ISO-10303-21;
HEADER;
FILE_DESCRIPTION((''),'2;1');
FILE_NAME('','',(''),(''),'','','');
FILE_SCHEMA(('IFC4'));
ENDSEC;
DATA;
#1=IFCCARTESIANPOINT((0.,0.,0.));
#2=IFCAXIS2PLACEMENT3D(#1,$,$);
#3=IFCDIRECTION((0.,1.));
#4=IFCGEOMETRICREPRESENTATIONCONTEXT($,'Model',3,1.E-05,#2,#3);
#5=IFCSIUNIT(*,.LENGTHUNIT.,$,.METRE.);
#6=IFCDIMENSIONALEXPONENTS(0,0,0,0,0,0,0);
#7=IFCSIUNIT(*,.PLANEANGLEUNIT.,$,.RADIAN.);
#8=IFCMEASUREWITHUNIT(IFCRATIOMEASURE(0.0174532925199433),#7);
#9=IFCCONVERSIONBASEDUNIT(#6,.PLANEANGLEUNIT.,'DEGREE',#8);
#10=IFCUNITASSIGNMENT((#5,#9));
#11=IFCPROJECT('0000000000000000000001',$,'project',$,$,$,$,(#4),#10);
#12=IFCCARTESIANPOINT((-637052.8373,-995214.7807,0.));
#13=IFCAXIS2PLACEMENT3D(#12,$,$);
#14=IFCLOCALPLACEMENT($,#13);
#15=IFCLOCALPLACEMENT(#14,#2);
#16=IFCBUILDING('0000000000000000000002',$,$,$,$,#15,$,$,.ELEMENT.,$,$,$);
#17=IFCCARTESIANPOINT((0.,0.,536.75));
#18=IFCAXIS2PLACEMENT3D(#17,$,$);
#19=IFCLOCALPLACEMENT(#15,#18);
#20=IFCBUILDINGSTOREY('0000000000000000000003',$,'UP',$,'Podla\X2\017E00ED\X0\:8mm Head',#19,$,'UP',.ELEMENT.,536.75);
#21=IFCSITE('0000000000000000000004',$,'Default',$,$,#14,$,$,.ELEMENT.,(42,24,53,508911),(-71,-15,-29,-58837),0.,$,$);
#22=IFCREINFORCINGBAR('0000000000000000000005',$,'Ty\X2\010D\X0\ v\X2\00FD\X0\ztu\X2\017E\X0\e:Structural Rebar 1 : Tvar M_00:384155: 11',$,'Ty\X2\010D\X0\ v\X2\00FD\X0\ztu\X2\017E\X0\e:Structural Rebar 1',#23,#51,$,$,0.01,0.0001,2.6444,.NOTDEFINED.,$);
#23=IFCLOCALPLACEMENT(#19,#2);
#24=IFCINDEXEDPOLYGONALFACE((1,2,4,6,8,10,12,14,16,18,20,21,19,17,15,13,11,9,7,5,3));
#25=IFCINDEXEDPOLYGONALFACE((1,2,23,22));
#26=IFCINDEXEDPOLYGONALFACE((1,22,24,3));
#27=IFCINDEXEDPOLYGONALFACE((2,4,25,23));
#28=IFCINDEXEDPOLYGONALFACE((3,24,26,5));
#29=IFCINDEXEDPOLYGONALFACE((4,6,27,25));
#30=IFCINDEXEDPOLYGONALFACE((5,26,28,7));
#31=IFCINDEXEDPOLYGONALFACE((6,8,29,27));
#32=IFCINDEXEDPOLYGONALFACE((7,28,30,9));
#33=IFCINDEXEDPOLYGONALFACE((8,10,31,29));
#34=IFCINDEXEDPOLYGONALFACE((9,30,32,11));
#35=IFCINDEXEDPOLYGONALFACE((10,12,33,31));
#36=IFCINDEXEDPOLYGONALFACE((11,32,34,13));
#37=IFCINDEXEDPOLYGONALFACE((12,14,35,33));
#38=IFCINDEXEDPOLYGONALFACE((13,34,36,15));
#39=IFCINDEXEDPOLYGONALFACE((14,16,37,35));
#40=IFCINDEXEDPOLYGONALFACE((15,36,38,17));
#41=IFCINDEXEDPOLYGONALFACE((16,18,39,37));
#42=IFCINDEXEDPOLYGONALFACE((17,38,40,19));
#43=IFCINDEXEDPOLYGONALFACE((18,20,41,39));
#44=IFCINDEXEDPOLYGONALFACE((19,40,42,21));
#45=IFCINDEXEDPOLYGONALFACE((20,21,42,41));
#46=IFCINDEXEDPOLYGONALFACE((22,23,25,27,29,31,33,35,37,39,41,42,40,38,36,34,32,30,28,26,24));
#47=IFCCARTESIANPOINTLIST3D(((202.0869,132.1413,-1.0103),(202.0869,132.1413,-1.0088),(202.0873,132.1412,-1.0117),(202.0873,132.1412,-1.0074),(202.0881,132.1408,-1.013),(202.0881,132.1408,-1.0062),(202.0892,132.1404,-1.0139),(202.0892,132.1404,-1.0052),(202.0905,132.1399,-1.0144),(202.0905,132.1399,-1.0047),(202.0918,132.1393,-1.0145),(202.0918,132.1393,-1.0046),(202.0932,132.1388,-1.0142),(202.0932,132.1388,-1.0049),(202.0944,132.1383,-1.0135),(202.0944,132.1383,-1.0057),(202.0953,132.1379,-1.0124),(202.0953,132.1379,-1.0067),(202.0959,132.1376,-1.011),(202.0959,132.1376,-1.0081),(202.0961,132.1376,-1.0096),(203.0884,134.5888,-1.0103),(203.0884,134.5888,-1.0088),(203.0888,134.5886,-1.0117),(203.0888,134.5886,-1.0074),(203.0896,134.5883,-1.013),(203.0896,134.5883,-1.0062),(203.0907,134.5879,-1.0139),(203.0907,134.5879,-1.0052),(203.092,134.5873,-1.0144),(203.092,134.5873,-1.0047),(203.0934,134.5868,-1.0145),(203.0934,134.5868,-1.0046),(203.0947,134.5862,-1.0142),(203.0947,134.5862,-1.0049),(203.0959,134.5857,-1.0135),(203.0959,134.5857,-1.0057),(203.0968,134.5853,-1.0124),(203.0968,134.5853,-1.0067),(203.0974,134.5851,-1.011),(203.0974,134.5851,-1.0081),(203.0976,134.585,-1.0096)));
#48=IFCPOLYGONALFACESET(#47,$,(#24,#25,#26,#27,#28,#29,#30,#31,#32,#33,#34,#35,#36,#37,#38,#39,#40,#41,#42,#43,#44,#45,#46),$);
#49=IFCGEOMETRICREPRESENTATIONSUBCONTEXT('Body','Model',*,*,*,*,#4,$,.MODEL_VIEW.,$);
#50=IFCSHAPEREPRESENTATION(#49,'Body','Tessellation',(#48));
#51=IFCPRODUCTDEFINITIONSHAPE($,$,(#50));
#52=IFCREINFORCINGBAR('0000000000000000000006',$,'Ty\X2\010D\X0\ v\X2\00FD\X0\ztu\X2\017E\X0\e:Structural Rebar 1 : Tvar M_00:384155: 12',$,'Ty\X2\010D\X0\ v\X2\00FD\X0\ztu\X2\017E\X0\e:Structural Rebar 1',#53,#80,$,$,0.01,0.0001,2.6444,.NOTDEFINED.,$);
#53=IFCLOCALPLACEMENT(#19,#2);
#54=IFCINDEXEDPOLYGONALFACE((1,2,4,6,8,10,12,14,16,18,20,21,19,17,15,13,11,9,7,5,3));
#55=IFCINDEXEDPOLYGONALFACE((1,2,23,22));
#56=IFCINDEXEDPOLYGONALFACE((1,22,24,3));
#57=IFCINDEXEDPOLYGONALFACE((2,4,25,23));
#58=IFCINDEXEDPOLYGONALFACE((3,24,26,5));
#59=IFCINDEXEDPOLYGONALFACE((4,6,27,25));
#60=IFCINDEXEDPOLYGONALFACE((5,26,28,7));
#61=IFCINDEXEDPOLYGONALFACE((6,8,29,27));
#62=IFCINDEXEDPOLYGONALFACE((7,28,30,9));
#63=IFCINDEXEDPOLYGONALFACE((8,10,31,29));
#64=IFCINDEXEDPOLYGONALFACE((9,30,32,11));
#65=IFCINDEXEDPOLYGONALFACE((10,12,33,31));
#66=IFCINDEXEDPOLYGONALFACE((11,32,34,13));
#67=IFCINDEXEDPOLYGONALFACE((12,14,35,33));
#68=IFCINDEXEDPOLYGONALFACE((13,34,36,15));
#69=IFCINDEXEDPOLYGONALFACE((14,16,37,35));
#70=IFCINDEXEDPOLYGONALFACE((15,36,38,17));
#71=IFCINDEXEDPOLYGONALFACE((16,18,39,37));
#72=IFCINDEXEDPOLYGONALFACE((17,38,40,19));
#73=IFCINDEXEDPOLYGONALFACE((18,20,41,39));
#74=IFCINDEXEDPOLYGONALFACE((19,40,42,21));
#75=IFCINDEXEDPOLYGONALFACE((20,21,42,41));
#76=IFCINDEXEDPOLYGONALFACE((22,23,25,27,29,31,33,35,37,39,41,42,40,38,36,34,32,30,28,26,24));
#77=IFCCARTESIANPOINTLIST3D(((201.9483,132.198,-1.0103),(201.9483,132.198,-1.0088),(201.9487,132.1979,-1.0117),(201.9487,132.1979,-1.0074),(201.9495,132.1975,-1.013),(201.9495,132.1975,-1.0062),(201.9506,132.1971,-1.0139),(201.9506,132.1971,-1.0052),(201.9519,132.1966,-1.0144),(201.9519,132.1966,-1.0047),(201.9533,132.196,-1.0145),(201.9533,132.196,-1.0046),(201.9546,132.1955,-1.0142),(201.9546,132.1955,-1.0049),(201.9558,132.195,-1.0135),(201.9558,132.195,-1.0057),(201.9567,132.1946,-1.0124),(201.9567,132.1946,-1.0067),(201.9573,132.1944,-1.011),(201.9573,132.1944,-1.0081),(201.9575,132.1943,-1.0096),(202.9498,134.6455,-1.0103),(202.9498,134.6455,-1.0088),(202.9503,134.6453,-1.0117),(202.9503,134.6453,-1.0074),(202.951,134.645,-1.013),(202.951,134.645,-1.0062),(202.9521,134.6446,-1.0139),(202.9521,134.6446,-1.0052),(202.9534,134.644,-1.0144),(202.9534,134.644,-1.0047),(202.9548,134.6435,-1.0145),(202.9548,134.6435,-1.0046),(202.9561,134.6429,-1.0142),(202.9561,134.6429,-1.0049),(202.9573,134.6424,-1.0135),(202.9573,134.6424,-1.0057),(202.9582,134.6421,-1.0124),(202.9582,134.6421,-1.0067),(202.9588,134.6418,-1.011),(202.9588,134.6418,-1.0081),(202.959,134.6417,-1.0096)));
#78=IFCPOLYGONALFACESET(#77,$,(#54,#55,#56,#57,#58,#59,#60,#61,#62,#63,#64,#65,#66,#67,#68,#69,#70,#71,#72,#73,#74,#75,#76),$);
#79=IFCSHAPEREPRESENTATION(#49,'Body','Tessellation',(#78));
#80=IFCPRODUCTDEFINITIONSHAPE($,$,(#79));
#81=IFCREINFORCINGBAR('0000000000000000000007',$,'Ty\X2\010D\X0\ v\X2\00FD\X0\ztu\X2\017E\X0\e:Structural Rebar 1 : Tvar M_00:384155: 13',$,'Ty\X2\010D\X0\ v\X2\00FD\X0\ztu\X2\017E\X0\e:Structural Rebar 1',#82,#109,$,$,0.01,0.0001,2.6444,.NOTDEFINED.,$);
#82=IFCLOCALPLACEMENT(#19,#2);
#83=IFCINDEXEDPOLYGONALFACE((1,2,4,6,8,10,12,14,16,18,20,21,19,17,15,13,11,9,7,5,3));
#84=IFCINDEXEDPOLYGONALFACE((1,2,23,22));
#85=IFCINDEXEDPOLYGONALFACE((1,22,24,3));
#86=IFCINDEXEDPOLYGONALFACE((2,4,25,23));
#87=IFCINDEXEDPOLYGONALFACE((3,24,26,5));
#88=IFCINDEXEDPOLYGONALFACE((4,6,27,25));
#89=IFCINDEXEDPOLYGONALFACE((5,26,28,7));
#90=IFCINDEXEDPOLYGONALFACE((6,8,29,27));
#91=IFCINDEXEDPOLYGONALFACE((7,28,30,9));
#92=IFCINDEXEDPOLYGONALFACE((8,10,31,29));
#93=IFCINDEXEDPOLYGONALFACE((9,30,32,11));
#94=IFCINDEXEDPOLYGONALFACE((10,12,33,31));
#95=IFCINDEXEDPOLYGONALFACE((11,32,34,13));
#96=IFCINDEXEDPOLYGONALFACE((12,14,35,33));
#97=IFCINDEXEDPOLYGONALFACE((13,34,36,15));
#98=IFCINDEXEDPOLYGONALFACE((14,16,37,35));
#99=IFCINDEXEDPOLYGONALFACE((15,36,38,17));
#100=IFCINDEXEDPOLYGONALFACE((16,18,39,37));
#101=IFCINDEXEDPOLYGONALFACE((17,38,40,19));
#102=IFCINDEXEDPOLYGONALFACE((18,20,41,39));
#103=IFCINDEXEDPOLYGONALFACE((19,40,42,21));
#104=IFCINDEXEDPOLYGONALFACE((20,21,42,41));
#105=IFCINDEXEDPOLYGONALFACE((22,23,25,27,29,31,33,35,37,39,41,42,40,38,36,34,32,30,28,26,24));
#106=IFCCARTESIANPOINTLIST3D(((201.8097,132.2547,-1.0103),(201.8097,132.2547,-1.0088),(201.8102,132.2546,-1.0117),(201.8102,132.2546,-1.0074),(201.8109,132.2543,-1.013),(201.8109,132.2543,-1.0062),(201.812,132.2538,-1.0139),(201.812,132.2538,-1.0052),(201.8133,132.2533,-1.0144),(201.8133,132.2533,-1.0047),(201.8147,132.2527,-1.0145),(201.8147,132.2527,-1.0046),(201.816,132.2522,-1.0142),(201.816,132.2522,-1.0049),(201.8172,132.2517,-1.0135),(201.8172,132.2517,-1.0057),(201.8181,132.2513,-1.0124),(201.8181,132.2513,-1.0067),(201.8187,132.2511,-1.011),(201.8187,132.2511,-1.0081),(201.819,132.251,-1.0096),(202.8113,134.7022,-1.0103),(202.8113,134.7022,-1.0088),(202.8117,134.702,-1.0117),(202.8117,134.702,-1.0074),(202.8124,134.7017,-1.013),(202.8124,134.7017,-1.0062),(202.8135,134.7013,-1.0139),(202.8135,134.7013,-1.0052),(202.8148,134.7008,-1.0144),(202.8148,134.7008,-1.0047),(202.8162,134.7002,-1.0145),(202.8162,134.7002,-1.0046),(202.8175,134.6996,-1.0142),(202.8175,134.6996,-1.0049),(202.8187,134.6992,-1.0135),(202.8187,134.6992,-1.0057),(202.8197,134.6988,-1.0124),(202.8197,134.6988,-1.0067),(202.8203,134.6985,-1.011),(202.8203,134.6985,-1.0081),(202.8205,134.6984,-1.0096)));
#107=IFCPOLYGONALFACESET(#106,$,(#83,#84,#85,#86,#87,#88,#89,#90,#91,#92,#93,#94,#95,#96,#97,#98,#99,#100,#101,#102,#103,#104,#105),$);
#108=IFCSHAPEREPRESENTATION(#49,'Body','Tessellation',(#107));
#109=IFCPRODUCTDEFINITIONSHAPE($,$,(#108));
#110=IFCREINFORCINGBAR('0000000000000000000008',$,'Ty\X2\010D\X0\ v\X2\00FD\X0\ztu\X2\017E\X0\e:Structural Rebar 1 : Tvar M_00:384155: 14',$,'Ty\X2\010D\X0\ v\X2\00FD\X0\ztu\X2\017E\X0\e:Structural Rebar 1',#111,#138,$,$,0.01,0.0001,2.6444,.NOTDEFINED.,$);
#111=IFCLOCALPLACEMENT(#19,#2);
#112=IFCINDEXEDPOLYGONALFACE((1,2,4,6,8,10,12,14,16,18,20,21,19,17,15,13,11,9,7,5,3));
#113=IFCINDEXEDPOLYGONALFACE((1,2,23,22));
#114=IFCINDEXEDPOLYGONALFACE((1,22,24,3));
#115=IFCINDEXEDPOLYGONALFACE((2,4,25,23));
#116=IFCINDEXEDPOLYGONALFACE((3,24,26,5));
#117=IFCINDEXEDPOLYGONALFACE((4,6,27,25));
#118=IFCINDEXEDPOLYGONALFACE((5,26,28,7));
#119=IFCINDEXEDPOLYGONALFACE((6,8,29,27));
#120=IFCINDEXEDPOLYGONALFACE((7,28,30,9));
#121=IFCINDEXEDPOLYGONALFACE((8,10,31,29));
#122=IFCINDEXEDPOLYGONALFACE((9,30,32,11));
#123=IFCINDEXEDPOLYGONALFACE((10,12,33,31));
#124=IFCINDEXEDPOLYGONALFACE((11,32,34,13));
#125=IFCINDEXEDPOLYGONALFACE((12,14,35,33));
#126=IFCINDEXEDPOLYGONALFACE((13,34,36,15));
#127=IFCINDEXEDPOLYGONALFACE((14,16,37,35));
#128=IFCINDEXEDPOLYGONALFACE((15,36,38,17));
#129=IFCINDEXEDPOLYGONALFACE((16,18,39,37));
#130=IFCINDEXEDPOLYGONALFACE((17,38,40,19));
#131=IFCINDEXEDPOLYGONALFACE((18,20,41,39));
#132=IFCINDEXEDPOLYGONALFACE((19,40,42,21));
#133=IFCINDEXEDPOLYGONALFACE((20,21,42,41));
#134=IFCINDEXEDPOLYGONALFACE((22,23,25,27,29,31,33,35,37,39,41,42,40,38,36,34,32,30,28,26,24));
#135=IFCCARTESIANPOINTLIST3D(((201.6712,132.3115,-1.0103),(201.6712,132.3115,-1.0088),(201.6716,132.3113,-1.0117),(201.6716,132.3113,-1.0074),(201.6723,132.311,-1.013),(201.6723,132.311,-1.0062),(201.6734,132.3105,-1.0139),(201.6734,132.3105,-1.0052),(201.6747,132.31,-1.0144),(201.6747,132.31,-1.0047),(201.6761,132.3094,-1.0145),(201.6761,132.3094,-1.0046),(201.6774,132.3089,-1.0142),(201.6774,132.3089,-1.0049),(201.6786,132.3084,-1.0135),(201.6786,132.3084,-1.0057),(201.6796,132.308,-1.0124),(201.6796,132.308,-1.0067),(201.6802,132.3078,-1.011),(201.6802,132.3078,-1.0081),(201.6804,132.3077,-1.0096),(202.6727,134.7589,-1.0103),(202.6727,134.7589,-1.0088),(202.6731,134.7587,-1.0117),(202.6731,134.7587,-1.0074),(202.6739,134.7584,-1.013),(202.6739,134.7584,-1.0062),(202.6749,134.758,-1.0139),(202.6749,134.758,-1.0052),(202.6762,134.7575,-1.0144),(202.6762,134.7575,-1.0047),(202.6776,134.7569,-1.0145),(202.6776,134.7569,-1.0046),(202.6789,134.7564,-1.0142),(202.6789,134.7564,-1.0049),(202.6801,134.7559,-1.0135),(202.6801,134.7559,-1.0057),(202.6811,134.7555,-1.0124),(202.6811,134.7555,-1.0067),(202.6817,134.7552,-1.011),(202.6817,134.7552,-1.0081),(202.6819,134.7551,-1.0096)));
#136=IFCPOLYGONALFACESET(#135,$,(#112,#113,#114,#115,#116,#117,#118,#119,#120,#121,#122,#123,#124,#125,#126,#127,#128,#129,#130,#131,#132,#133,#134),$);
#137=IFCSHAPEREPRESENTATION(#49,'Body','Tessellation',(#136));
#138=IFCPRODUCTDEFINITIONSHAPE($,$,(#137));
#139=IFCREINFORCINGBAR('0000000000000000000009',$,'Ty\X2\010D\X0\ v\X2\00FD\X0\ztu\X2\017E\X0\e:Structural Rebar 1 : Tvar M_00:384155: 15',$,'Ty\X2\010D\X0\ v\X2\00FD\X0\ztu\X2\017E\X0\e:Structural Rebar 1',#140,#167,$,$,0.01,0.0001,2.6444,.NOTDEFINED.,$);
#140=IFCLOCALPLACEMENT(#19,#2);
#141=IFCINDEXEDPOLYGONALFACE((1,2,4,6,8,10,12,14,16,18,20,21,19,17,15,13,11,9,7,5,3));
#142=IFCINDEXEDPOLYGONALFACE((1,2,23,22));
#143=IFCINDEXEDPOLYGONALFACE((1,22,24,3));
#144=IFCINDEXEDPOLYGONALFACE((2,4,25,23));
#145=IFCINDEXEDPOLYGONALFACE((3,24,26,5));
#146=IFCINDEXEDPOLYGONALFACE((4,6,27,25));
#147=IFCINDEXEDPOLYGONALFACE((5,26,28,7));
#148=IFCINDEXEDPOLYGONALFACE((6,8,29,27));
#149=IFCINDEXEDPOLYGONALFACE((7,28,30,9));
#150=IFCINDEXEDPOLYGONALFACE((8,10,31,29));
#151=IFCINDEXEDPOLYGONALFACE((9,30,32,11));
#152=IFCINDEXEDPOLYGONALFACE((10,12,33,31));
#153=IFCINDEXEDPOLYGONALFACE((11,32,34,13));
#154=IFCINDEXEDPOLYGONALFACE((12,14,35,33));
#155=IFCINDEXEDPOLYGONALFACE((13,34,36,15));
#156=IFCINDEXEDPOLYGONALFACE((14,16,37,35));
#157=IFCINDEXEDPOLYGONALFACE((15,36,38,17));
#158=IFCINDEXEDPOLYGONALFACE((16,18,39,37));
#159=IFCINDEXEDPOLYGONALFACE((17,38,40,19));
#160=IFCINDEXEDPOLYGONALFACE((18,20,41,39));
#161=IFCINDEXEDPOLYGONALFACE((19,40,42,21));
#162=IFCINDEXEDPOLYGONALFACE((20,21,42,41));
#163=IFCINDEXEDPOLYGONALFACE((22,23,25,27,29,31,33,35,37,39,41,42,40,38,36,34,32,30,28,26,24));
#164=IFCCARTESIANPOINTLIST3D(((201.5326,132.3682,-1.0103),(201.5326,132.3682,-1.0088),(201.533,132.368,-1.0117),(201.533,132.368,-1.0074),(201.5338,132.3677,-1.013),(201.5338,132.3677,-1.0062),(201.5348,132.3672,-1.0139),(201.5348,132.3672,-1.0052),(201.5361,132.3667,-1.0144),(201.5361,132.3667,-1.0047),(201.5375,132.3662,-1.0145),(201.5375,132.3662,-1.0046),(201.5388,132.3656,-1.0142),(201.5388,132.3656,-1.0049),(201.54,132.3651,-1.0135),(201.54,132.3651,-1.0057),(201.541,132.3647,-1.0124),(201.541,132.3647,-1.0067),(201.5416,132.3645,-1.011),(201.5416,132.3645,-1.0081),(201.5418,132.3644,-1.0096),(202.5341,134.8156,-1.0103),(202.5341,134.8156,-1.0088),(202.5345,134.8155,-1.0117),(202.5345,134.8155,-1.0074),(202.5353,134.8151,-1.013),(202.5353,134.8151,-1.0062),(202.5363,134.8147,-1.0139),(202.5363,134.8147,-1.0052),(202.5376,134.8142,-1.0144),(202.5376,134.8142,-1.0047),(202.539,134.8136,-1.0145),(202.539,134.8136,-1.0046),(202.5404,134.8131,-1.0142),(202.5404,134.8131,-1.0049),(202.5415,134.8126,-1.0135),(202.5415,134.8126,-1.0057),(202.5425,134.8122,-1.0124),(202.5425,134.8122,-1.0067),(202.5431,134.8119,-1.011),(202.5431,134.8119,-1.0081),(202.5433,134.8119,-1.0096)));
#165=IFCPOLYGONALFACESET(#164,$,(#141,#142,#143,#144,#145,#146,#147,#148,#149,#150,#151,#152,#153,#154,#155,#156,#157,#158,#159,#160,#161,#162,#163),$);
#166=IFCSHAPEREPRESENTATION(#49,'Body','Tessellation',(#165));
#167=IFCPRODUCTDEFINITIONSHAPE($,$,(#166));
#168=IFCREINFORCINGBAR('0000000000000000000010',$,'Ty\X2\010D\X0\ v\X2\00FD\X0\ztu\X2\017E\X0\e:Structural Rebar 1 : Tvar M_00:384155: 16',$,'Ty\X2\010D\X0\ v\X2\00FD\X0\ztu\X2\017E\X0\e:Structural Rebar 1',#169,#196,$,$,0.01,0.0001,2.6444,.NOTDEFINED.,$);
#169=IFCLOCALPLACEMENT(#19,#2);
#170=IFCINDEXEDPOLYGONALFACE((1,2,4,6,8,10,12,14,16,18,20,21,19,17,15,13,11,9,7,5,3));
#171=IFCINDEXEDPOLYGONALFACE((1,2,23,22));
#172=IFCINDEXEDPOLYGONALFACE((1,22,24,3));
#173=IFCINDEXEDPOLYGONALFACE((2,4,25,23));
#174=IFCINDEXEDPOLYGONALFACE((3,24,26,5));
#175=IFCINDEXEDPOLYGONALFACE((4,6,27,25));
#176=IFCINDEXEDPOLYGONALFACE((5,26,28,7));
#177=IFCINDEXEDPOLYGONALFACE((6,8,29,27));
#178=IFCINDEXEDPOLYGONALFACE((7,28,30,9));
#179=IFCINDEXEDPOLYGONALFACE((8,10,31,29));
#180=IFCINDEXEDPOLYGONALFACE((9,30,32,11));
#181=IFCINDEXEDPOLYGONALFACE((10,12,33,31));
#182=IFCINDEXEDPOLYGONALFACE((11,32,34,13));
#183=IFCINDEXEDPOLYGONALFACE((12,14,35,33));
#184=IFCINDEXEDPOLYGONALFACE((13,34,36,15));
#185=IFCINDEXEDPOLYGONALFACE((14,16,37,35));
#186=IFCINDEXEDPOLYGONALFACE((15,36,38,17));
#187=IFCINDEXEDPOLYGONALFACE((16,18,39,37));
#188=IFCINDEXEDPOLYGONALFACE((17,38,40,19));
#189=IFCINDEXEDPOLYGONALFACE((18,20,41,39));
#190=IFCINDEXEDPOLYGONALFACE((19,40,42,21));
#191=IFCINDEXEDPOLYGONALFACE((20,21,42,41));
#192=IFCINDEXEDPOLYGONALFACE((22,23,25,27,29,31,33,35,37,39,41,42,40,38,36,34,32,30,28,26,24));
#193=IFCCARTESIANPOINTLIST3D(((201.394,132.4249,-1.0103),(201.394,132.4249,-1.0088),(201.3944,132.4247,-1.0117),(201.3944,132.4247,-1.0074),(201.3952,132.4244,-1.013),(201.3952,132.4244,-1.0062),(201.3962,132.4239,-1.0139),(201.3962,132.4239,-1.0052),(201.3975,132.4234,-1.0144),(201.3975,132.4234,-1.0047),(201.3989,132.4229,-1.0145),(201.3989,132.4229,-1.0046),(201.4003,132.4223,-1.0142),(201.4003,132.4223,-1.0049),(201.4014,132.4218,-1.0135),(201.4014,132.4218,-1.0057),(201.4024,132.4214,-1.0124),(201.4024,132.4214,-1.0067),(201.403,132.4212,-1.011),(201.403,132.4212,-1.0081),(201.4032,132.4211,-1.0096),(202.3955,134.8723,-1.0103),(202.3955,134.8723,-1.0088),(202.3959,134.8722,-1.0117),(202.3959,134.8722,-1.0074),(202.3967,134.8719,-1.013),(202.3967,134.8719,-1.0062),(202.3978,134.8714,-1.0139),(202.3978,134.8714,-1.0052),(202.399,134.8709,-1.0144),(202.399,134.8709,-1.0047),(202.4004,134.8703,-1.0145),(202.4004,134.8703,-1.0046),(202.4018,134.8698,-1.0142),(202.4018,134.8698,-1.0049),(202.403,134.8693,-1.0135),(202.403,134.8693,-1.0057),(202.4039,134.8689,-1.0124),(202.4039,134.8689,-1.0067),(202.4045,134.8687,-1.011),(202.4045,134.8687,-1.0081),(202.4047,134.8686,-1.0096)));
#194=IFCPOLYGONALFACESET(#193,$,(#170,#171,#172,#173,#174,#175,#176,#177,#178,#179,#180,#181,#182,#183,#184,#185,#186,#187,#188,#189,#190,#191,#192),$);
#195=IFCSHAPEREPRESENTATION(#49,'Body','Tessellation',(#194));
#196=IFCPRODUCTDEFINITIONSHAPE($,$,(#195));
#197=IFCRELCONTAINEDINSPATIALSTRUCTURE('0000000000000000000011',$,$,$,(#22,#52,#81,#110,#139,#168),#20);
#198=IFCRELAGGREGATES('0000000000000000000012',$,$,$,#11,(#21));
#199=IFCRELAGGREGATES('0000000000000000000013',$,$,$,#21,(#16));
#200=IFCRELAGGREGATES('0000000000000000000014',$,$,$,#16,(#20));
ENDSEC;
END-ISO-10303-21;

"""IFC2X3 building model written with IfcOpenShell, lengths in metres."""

from ifc_helpers import new_model, entity, si_unit, converted_unit, direction, frame, origin, place, context, subcontext, project, spatial, element, save


model = new_model("IFC2X3")

# Units and contexts
model_context = context("Model", 3, precision=1e-05, world=origin(), true_north=direction((0.0, 1.0)))
body_context = subcontext(model_context, "Body", "Model", "MODEL_VIEW")
ifc_project = project(units=[si_unit("LENGTHUNIT", "METRE"), converted_unit("PLANEANGLEUNIT", "DEGREE", entity("IfcRatioMeasure", 0.0174532925199433), si_unit("PLANEANGLEUNIT", "RADIAN"), dimensions=[0, 0, 0, 0, 0, 0, 0])], contexts=[model_context])

# Site, building, storey
site_placement = place(None, frame((-637052.8373, -995214.7807, 0.0)))
site = spatial("IfcSite", under=ifc_project, at=site_placement, Name="Default", CompositionType="ELEMENT", RefLatitude=(42, 24, 53, 508911), RefLongitude=(-71, -15, -29, -58837), RefElevation=0.0)
building_placement = place(site_placement, origin())
building = spatial("IfcBuilding", under=site, at=building_placement, CompositionType="ELEMENT")
storey_placement = place(building_placement, frame((0.0, 0.0, 536.75)))
storey = spatial("IfcBuildingStorey", under=building, at=storey_placement, Name="UP", ObjectType="Podlaží:8mm Head", LongName="UP", CompositionType="ELEMENT", Elevation=536.75)

# Reinforcing bars
reinforcing_bar_1_placement = place(storey_placement, origin())
element("IfcReinforcingBar", 1, at=reinforcing_bar_1_placement, inside=storey, Name="Tyč výztuže:Structural Rebar 1 : Tvar M_00:384155: 11", ObjectType="Tyč výztuže:Structural Rebar 1", BarLength=2.6444, BarRole="NOTDEFINED", CrossSectionArea=0.0001, NominalDiameter=0.01, context=body_context, shape_type="AdvancedSweptSolid", body=[
    entity("IfcSweptDiskSolid", entity("IfcCompositeCurve", [entity("IfcCompositeCurveSegment", "CONTINUOUS", True, entity("IfcPolyline", [entity("IfcCartesianPoint", [-203.093, -134.5869, 1.0096]), entity("IfcCartesianPoint", [-202.0915, -132.1395, 1.0096])]))], False), 0.005, None, 0.0, 1.0),
])
reinforcing_bar_2_placement = place(storey_placement, origin())
element("IfcReinforcingBar", 2, at=reinforcing_bar_2_placement, inside=storey, Name="Tyč výztuže:Structural Rebar 1 : Tvar M_00:384155: 12", ObjectType="Tyč výztuže:Structural Rebar 1", BarLength=2.6444, BarRole="NOTDEFINED", CrossSectionArea=0.0001, NominalDiameter=0.01, context=body_context, shape_type="AdvancedSweptSolid", body=[
    entity("IfcSweptDiskSolid", entity("IfcCompositeCurve", [entity("IfcCompositeCurveSegment", "CONTINUOUS", True, entity("IfcPolyline", [entity("IfcCartesianPoint", [-202.9544, -134.6436, 1.0096]), entity("IfcCartesianPoint", [-201.9529, -132.1962, 1.0096])]))], False), 0.005, None, 0.0, 1.0),
])
reinforcing_bar_3_placement = place(storey_placement, origin())
element("IfcReinforcingBar", 3, at=reinforcing_bar_3_placement, inside=storey, Name="Tyč výztuže:Structural Rebar 1 : Tvar M_00:384155: 13", ObjectType="Tyč výztuže:Structural Rebar 1", BarLength=2.6444, BarRole="NOTDEFINED", CrossSectionArea=0.0001, NominalDiameter=0.01, context=body_context, shape_type="AdvancedSweptSolid", body=[
    entity("IfcSweptDiskSolid", entity("IfcCompositeCurve", [entity("IfcCompositeCurveSegment", "CONTINUOUS", True, entity("IfcPolyline", [entity("IfcCartesianPoint", [-202.8158, -134.7003, 1.0096]), entity("IfcCartesianPoint", [-201.8143, -132.2529, 1.0096])]))], False), 0.005, None, 0.0, 1.0),
])
reinforcing_bar_4_placement = place(storey_placement, origin())
element("IfcReinforcingBar", 4, at=reinforcing_bar_4_placement, inside=storey, Name="Tyč výztuže:Structural Rebar 1 : Tvar M_00:384155: 14", ObjectType="Tyč výztuže:Structural Rebar 1", BarLength=2.6444, BarRole="NOTDEFINED", CrossSectionArea=0.0001, NominalDiameter=0.01, context=body_context, shape_type="AdvancedSweptSolid", body=[
    entity("IfcSweptDiskSolid", entity("IfcCompositeCurve", [entity("IfcCompositeCurveSegment", "CONTINUOUS", True, entity("IfcPolyline", [entity("IfcCartesianPoint", [-202.6772, -134.757, 1.0096]), entity("IfcCartesianPoint", [-201.6757, -132.3096, 1.0096])]))], False), 0.005, None, 0.0, 1.0),
])
reinforcing_bar_5_placement = place(storey_placement, origin())
element("IfcReinforcingBar", 5, at=reinforcing_bar_5_placement, inside=storey, Name="Tyč výztuže:Structural Rebar 1 : Tvar M_00:384155: 15", ObjectType="Tyč výztuže:Structural Rebar 1", BarLength=2.6444, BarRole="NOTDEFINED", CrossSectionArea=0.0001, NominalDiameter=0.01, context=body_context, shape_type="AdvancedSweptSolid", body=[
    entity("IfcSweptDiskSolid", entity("IfcCompositeCurve", [entity("IfcCompositeCurveSegment", "CONTINUOUS", True, entity("IfcPolyline", [entity("IfcCartesianPoint", [-202.5387, -134.8138, 1.0096]), entity("IfcCartesianPoint", [-201.5372, -132.3663, 1.0096])]))], False), 0.005, None, 0.0, 1.0),
])
reinforcing_bar_6_placement = place(storey_placement, origin())
element("IfcReinforcingBar", 6, at=reinforcing_bar_6_placement, inside=storey, Name="Tyč výztuže:Structural Rebar 1 : Tvar M_00:384155: 16", ObjectType="Tyč výztuže:Structural Rebar 1", BarLength=2.6444, BarRole="NOTDEFINED", CrossSectionArea=0.0001, NominalDiameter=0.01, context=body_context, shape_type="AdvancedSweptSolid", body=[
    entity("IfcSweptDiskSolid", entity("IfcCompositeCurve", [entity("IfcCompositeCurveSegment", "CONTINUOUS", True, entity("IfcPolyline", [entity("IfcCartesianPoint", [-202.4001, -134.8705, 1.0096]), entity("IfcCartesianPoint", [-201.3986, -132.423, 1.0096])]))], False), 0.005, None, 0.0, 1.0),
])

save(model, "model.ifc")
